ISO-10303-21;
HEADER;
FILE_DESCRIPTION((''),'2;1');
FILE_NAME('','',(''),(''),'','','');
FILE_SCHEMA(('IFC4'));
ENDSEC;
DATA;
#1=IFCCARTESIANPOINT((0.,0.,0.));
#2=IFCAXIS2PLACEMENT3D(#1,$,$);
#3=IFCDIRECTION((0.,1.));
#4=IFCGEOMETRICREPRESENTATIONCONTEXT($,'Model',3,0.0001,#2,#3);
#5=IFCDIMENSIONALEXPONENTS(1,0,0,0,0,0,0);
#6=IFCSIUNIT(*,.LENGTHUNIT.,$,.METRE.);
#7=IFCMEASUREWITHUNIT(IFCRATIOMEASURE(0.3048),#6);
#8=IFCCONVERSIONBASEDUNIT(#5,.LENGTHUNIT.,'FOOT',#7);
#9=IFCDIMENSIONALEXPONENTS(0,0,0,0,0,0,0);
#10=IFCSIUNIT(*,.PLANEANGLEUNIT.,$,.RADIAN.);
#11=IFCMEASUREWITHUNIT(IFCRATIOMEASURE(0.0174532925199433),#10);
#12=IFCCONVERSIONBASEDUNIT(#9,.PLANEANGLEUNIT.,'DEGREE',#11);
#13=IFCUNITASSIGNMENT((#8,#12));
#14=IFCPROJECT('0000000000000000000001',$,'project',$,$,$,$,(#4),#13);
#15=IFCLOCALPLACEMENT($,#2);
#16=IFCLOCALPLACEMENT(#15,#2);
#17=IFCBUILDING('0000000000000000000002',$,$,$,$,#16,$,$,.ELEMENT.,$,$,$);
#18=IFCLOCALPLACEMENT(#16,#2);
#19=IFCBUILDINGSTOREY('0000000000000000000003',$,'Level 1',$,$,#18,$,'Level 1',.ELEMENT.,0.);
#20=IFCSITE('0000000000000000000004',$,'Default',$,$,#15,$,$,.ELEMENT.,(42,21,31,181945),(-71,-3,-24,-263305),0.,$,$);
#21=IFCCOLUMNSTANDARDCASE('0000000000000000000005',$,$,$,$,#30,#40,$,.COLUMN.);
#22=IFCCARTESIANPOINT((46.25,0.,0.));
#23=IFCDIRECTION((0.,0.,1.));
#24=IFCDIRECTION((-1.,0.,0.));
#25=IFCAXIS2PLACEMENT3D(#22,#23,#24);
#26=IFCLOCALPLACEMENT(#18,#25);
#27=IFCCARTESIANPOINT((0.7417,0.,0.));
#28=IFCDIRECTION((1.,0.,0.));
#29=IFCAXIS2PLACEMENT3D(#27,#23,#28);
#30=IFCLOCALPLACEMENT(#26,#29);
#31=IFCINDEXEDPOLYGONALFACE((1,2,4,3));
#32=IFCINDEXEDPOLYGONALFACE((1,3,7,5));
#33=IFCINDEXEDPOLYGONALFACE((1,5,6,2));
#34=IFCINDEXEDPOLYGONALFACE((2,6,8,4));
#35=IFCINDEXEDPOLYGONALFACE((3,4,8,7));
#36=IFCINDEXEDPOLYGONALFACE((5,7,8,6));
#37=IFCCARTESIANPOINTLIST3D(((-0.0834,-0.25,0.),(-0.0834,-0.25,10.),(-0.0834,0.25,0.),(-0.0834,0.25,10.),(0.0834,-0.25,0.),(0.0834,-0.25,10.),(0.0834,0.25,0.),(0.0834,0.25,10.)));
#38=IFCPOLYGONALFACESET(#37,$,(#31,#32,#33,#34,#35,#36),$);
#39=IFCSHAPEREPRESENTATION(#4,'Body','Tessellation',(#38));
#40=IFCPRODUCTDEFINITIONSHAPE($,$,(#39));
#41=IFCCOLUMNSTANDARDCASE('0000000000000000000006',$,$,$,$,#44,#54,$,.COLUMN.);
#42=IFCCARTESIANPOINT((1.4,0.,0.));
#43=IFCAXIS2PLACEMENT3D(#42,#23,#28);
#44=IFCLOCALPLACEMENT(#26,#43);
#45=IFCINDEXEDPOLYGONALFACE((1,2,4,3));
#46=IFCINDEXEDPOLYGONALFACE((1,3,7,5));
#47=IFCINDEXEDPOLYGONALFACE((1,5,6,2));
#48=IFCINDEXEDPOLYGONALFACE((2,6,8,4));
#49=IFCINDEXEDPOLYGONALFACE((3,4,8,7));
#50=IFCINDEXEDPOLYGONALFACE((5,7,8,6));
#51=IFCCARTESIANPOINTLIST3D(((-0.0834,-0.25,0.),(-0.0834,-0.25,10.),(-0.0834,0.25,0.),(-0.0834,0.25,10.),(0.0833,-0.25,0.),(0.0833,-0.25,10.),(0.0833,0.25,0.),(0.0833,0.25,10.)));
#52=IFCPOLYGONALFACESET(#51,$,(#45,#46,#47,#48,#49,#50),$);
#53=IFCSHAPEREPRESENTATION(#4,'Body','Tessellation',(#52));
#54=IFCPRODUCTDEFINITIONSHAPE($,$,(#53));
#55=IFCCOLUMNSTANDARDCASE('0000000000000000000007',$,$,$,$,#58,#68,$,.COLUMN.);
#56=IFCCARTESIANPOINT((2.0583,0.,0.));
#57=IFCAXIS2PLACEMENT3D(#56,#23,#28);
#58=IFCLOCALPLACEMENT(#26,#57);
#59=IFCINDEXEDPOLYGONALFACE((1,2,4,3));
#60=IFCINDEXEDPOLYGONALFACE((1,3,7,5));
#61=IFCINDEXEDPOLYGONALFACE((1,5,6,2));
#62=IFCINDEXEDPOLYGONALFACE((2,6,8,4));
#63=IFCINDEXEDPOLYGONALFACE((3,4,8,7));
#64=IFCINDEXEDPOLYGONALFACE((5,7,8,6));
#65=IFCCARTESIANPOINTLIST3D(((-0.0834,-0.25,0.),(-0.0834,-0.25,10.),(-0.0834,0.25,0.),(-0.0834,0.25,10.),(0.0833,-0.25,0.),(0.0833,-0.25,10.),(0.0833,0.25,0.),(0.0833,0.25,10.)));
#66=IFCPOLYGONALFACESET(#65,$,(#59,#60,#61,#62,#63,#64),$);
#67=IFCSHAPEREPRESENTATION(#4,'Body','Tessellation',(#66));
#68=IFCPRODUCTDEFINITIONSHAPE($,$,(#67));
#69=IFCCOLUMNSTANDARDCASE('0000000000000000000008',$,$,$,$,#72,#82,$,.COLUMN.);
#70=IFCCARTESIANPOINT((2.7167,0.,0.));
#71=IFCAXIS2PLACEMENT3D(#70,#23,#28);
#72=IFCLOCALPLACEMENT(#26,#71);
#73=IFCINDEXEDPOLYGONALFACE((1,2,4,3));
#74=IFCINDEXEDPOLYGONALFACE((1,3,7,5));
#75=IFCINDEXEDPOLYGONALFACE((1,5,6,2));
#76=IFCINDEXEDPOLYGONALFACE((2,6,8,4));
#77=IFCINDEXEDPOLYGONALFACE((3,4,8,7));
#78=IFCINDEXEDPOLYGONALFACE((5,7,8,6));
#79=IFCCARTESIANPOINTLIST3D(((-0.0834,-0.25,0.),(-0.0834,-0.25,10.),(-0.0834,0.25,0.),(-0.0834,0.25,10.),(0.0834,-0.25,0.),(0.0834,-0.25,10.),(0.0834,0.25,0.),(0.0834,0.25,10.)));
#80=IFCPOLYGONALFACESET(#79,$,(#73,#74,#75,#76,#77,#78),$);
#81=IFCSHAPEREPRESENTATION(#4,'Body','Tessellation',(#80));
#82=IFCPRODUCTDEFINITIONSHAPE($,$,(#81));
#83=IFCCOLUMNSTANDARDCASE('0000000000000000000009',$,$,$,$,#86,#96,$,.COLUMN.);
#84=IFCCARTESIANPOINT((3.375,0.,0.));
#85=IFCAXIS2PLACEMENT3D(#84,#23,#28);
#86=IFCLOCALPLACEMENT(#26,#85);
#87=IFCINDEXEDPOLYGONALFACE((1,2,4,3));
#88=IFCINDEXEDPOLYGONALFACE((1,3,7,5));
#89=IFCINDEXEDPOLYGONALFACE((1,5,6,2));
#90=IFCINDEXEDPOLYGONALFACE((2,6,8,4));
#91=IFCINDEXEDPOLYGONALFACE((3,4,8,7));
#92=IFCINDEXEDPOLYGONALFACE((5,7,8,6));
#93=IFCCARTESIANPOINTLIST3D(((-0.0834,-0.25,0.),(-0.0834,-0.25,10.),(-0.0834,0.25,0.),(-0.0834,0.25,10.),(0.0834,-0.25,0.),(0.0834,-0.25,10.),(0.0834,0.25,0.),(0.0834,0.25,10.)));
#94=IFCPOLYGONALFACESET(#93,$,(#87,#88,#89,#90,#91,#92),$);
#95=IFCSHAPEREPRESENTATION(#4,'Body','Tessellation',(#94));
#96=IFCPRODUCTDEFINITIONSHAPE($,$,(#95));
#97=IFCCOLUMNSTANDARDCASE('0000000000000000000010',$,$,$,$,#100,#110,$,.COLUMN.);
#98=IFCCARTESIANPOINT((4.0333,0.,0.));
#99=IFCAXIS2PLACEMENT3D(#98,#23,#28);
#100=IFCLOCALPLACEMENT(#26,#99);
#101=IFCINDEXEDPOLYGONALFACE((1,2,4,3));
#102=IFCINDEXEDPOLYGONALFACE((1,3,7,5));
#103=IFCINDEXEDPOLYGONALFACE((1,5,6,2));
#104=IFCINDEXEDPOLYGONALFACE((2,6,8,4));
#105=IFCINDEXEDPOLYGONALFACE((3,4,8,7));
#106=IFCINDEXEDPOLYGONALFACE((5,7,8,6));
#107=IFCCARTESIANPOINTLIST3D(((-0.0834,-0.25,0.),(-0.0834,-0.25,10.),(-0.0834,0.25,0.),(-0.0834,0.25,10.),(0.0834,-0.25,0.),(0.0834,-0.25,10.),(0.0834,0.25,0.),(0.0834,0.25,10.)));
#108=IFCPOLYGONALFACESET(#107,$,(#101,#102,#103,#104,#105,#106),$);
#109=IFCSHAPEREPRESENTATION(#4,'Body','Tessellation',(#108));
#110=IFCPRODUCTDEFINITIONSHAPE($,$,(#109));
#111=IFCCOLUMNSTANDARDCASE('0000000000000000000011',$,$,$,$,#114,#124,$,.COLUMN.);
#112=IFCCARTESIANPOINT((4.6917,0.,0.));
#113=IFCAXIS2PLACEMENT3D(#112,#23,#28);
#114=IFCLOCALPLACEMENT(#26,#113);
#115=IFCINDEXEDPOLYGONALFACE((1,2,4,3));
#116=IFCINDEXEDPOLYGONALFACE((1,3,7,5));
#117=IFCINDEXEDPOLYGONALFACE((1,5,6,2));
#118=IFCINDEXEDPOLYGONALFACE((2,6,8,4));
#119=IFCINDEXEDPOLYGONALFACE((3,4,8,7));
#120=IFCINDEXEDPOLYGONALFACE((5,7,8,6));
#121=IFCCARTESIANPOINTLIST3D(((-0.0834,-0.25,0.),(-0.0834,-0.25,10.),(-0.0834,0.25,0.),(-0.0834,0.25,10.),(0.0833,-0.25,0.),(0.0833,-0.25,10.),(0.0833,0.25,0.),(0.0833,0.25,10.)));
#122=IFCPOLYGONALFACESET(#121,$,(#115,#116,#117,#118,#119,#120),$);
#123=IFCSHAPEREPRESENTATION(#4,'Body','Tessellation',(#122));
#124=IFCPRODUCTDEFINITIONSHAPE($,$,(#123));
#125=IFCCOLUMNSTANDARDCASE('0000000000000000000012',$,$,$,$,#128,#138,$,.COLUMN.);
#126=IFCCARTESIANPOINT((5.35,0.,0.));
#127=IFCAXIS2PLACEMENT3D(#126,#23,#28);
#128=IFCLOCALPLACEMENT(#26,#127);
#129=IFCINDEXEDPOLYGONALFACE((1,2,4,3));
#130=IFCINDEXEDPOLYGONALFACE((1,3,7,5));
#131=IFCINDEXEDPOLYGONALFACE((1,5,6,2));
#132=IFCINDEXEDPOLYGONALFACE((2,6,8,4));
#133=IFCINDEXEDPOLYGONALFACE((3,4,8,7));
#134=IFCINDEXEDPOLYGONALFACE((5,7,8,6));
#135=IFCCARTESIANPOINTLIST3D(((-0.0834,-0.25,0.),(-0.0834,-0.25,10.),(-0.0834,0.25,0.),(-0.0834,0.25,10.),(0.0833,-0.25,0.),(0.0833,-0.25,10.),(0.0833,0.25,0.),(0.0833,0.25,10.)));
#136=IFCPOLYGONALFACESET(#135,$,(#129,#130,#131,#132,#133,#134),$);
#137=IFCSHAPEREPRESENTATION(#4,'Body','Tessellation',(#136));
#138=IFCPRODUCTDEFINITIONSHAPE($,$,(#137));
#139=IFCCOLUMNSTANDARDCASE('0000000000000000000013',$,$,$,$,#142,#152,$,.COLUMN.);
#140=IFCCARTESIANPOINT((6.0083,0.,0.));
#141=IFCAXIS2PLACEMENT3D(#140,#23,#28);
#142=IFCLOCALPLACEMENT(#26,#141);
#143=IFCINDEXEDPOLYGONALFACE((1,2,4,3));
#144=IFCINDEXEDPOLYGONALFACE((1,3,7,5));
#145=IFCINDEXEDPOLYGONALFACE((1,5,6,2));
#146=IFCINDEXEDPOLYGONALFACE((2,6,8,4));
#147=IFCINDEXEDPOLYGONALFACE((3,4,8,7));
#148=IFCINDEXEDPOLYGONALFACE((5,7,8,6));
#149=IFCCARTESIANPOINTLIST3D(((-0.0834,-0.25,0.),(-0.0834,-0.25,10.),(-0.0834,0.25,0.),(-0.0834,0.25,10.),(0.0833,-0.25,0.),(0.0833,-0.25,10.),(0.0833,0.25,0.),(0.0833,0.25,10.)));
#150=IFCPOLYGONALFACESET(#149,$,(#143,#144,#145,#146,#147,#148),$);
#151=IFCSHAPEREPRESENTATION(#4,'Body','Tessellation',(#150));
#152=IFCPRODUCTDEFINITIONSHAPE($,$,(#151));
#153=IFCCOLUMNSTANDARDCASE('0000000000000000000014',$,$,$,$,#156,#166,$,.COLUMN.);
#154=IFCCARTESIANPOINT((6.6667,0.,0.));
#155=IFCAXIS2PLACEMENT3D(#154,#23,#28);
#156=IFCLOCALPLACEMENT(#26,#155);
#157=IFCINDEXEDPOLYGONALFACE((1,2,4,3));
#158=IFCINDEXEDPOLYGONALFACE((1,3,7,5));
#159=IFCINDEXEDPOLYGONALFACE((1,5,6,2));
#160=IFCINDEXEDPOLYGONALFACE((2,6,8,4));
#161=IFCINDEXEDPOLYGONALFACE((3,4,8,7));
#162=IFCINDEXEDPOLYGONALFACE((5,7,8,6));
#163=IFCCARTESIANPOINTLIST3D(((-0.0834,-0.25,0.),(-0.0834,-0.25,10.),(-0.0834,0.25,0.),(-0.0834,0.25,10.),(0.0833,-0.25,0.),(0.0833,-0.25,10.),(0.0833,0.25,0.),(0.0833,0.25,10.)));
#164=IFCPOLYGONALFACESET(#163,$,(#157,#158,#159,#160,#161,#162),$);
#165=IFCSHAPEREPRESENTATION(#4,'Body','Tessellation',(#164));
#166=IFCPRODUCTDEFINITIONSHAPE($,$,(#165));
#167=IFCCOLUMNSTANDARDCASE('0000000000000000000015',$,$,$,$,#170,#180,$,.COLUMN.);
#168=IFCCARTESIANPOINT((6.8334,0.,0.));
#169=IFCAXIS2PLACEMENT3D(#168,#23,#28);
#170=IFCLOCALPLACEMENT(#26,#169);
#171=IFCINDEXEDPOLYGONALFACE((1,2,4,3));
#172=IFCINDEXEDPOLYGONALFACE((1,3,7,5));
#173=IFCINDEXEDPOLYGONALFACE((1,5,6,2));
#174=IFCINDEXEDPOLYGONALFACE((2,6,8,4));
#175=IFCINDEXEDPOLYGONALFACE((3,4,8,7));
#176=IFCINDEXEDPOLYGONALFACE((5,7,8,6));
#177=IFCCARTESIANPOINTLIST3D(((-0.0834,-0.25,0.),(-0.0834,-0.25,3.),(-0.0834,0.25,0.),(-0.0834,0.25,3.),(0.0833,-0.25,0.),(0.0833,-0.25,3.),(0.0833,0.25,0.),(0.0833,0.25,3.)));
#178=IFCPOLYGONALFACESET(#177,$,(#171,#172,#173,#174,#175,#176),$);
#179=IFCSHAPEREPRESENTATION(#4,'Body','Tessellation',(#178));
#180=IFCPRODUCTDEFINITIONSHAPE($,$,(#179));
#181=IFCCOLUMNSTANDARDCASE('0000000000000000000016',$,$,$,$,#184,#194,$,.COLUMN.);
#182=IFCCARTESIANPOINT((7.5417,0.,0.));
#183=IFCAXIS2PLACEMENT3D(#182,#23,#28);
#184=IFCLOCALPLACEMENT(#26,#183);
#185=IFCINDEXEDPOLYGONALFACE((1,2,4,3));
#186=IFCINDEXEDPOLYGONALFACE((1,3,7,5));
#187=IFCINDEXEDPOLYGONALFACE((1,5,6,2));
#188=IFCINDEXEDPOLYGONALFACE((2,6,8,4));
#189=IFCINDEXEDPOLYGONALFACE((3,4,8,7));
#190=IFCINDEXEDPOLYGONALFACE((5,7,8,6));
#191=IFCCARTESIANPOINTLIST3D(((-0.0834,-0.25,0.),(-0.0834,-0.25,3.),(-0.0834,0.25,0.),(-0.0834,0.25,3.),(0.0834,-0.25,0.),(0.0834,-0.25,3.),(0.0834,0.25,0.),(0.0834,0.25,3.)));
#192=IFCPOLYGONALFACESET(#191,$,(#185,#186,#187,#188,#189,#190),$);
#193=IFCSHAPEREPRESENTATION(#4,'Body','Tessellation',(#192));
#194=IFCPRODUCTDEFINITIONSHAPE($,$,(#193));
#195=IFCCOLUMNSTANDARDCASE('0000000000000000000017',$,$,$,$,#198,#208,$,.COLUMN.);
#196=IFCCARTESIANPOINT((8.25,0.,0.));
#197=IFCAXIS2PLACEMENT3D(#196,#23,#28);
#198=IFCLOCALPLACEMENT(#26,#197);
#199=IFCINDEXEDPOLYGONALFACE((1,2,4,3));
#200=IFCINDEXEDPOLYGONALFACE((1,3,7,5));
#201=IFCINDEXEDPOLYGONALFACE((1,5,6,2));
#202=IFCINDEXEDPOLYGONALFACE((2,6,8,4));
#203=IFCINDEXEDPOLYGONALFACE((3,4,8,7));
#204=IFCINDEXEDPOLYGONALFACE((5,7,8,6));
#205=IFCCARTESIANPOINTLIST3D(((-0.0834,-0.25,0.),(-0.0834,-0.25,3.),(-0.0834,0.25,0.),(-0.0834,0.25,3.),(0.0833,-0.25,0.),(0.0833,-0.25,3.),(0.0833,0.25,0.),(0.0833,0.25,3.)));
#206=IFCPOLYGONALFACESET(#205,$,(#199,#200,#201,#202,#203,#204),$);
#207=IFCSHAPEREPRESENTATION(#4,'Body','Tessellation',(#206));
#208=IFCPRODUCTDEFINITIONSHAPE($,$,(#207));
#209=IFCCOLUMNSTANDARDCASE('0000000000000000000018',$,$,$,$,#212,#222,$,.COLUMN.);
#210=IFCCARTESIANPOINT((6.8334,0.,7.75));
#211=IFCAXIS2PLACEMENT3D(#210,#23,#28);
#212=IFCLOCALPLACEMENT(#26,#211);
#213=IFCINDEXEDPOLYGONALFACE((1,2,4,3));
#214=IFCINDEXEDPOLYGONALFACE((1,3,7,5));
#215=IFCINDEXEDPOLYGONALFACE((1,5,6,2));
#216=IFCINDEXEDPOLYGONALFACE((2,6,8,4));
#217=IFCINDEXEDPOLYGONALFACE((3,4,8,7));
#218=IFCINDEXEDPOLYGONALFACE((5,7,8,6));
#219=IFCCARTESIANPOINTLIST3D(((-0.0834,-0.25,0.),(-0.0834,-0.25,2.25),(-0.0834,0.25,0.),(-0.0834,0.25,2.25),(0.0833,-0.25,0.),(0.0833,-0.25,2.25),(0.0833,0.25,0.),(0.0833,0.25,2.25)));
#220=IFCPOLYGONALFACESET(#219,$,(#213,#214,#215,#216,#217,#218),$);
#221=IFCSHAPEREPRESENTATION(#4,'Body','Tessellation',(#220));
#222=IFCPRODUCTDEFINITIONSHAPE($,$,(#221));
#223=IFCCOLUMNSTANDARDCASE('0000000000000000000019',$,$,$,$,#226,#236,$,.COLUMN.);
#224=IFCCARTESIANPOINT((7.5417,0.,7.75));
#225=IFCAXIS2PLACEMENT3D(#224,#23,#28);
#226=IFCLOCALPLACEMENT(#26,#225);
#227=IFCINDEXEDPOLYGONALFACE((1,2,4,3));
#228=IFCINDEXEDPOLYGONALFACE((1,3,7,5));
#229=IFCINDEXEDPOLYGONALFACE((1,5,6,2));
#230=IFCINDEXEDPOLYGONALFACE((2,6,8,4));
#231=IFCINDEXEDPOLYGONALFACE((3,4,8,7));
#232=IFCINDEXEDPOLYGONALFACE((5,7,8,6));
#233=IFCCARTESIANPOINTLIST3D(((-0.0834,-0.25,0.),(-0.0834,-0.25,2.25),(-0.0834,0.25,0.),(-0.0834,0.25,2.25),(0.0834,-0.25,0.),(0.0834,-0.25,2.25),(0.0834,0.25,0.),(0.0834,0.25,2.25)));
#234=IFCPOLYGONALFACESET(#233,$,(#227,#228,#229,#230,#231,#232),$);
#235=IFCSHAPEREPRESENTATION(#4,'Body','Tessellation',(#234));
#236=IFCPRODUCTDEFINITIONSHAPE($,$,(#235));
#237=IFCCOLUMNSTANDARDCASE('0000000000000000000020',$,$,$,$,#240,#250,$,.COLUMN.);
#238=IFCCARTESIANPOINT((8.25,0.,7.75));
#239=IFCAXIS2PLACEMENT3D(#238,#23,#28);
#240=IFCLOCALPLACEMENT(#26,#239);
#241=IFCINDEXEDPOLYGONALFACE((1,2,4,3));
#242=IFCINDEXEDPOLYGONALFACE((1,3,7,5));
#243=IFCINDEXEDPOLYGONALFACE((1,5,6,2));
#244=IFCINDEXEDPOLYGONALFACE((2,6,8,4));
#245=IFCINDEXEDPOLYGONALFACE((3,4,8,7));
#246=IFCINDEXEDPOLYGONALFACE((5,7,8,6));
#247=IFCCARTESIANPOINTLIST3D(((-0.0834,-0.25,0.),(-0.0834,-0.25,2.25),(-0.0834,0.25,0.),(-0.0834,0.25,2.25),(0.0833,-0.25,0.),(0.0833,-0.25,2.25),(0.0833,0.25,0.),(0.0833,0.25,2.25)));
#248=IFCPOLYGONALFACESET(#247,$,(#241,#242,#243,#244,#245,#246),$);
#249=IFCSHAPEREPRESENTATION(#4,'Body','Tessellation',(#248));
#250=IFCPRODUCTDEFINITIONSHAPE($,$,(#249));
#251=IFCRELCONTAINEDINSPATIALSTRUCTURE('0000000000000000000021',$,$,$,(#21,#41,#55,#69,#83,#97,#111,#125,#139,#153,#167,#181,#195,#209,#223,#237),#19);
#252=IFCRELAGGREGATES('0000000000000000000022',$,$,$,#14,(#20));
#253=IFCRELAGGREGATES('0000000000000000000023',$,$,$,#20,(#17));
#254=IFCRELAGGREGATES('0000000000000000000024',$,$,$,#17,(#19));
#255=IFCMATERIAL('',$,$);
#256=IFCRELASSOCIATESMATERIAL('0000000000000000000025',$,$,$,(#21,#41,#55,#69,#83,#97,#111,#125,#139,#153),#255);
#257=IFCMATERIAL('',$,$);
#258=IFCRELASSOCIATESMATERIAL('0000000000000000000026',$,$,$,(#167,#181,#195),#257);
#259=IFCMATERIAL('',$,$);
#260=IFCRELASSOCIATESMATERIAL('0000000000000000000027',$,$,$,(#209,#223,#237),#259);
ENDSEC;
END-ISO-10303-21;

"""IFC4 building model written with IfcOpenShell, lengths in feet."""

from ifc_helpers import new_model, entity, si_unit, converted_unit, direction, frame, origin, place, context, project, spatial, rectangle, extrude, material, element, save


model = new_model("IFC4")

# Units and contexts
model_context = context("Model", 3, precision=0.0001, world=origin(), true_north=direction((0.0, 1.0)))
ifc_project = project(units=[converted_unit("LENGTHUNIT", "FOOT", entity("IfcRatioMeasure", 0.3048), si_unit("LENGTHUNIT", "METRE"), dimensions=[1, 0, 0, 0, 0, 0, 0]), converted_unit("PLANEANGLEUNIT", "DEGREE", entity("IfcRatioMeasure", 0.0174532925199433), si_unit("PLANEANGLEUNIT", "RADIAN"), dimensions=[0, 0, 0, 0, 0, 0, 0])], contexts=[model_context])

# Site, building, storey
site_placement = place(None, origin())
site = spatial("IfcSite", under=ifc_project, at=site_placement, Name="Default", CompositionType="ELEMENT", RefLatitude=(42, 21, 31, 181945), RefLongitude=(-71, -3, -24, -263305), RefElevation=0.0)
building_placement = place(site_placement, origin())
building = spatial("IfcBuilding", under=site, at=building_placement, CompositionType="ELEMENT")
storey_placement = place(building_placement, origin())
storey = spatial("IfcBuildingStorey", under=building, at=storey_placement, Name="Level 1", LongName="Level 1", CompositionType="ELEMENT", Elevation=0.0)

# Columns
ifc_material_1 = material(Name="")
placement_1 = place(storey_placement, frame((46.25, 0.0, 0.0), z_axis=(0.0, 0.0, 1.0), x_axis=(-1.0, 0.0, 0.0)))
for number, where, z_axis, x_axis in (
    (1, (0.7417, 0.0, 0.0), (0.0, 0.0, 1.0), (1.0, 0.0, 0.0)),
    (2, (1.4, 0.0, 0.0), (0.0, 0.0, 1.0), (1.0, 0.0, 0.0)),
    (3, (2.0583, 0.0, 0.0), (0.0, 0.0, 1.0), (1.0, 0.0, 0.0)),
    (4, (2.7167, 0.0, 0.0), (0.0, 0.0, 1.0), (1.0, 0.0, 0.0)),
    (5, (3.375, 0.0, 0.0), (0.0, 0.0, 1.0), (1.0, 0.0, 0.0)),
    (6, (4.0333, 0.0, 0.0), (0.0, 0.0, 1.0), (1.0, 0.0, 0.0)),
    (7, (4.6917, 0.0, 0.0), (0.0, 0.0, 1.0), (1.0, 0.0, 0.0)),
    (8, (5.35, 0.0, 0.0), (0.0, 0.0, 1.0), (1.0, 0.0, 0.0)),
    (9, (6.0083, 0.0, 0.0), (0.0, 0.0, 1.0), (1.0, 0.0, 0.0)),
    (10, (6.6667, 0.0, 0.0), (0.0, 0.0, 1.0), (1.0, 0.0, 0.0)),
):
    element("IfcColumnStandardCase", number, at=place(placement_1, frame(where, z_axis=z_axis, x_axis=x_axis)), inside=storey, material=ifc_material_1, PredefinedType="COLUMN", context=model_context, shape_type="SweptSolid", body=[
        extrude(rectangle(XDim=0.1667, YDim=0.5), origin(), (0.0, 0.0, 1.0), 10.0),
    ])
ifc_material_2 = material(Name="")
for number, where, z_axis, x_axis in (
    (11, (6.8334, 0.0, 0.0), (0.0, 0.0, 1.0), (1.0, 0.0, 0.0)),
    (12, (7.5417, 0.0, 0.0), (0.0, 0.0, 1.0), (1.0, 0.0, 0.0)),
    (13, (8.25, 0.0, 0.0), (0.0, 0.0, 1.0), (1.0, 0.0, 0.0)),
):
    element("IfcColumnStandardCase", number, at=place(placement_1, frame(where, z_axis=z_axis, x_axis=x_axis)), inside=storey, material=ifc_material_2, PredefinedType="COLUMN", context=model_context, shape_type="SweptSolid", body=[
        extrude(rectangle(XDim=0.1667, YDim=0.5), origin(), (0.0, 0.0, 1.0), 3.0),
    ])
ifc_material_3 = material(Name="")
for number, where, z_axis, x_axis in (
    (14, (6.8334, 0.0, 7.75), (0.0, 0.0, 1.0), (1.0, 0.0, 0.0)),
    (15, (7.5417, 0.0, 7.75), (0.0, 0.0, 1.0), (1.0, 0.0, 0.0)),
    (16, (8.25, 0.0, 7.75), (0.0, 0.0, 1.0), (1.0, 0.0, 0.0)),
):
    element("IfcColumnStandardCase", number, at=place(placement_1, frame(where, z_axis=z_axis, x_axis=x_axis)), inside=storey, material=ifc_material_3, PredefinedType="COLUMN", context=model_context, shape_type="SweptSolid", body=[
        extrude(rectangle(XDim=0.1667, YDim=0.5), origin(), (0.0, 0.0, 1.0), 2.25),
    ])

save(model, "model.ifc")
